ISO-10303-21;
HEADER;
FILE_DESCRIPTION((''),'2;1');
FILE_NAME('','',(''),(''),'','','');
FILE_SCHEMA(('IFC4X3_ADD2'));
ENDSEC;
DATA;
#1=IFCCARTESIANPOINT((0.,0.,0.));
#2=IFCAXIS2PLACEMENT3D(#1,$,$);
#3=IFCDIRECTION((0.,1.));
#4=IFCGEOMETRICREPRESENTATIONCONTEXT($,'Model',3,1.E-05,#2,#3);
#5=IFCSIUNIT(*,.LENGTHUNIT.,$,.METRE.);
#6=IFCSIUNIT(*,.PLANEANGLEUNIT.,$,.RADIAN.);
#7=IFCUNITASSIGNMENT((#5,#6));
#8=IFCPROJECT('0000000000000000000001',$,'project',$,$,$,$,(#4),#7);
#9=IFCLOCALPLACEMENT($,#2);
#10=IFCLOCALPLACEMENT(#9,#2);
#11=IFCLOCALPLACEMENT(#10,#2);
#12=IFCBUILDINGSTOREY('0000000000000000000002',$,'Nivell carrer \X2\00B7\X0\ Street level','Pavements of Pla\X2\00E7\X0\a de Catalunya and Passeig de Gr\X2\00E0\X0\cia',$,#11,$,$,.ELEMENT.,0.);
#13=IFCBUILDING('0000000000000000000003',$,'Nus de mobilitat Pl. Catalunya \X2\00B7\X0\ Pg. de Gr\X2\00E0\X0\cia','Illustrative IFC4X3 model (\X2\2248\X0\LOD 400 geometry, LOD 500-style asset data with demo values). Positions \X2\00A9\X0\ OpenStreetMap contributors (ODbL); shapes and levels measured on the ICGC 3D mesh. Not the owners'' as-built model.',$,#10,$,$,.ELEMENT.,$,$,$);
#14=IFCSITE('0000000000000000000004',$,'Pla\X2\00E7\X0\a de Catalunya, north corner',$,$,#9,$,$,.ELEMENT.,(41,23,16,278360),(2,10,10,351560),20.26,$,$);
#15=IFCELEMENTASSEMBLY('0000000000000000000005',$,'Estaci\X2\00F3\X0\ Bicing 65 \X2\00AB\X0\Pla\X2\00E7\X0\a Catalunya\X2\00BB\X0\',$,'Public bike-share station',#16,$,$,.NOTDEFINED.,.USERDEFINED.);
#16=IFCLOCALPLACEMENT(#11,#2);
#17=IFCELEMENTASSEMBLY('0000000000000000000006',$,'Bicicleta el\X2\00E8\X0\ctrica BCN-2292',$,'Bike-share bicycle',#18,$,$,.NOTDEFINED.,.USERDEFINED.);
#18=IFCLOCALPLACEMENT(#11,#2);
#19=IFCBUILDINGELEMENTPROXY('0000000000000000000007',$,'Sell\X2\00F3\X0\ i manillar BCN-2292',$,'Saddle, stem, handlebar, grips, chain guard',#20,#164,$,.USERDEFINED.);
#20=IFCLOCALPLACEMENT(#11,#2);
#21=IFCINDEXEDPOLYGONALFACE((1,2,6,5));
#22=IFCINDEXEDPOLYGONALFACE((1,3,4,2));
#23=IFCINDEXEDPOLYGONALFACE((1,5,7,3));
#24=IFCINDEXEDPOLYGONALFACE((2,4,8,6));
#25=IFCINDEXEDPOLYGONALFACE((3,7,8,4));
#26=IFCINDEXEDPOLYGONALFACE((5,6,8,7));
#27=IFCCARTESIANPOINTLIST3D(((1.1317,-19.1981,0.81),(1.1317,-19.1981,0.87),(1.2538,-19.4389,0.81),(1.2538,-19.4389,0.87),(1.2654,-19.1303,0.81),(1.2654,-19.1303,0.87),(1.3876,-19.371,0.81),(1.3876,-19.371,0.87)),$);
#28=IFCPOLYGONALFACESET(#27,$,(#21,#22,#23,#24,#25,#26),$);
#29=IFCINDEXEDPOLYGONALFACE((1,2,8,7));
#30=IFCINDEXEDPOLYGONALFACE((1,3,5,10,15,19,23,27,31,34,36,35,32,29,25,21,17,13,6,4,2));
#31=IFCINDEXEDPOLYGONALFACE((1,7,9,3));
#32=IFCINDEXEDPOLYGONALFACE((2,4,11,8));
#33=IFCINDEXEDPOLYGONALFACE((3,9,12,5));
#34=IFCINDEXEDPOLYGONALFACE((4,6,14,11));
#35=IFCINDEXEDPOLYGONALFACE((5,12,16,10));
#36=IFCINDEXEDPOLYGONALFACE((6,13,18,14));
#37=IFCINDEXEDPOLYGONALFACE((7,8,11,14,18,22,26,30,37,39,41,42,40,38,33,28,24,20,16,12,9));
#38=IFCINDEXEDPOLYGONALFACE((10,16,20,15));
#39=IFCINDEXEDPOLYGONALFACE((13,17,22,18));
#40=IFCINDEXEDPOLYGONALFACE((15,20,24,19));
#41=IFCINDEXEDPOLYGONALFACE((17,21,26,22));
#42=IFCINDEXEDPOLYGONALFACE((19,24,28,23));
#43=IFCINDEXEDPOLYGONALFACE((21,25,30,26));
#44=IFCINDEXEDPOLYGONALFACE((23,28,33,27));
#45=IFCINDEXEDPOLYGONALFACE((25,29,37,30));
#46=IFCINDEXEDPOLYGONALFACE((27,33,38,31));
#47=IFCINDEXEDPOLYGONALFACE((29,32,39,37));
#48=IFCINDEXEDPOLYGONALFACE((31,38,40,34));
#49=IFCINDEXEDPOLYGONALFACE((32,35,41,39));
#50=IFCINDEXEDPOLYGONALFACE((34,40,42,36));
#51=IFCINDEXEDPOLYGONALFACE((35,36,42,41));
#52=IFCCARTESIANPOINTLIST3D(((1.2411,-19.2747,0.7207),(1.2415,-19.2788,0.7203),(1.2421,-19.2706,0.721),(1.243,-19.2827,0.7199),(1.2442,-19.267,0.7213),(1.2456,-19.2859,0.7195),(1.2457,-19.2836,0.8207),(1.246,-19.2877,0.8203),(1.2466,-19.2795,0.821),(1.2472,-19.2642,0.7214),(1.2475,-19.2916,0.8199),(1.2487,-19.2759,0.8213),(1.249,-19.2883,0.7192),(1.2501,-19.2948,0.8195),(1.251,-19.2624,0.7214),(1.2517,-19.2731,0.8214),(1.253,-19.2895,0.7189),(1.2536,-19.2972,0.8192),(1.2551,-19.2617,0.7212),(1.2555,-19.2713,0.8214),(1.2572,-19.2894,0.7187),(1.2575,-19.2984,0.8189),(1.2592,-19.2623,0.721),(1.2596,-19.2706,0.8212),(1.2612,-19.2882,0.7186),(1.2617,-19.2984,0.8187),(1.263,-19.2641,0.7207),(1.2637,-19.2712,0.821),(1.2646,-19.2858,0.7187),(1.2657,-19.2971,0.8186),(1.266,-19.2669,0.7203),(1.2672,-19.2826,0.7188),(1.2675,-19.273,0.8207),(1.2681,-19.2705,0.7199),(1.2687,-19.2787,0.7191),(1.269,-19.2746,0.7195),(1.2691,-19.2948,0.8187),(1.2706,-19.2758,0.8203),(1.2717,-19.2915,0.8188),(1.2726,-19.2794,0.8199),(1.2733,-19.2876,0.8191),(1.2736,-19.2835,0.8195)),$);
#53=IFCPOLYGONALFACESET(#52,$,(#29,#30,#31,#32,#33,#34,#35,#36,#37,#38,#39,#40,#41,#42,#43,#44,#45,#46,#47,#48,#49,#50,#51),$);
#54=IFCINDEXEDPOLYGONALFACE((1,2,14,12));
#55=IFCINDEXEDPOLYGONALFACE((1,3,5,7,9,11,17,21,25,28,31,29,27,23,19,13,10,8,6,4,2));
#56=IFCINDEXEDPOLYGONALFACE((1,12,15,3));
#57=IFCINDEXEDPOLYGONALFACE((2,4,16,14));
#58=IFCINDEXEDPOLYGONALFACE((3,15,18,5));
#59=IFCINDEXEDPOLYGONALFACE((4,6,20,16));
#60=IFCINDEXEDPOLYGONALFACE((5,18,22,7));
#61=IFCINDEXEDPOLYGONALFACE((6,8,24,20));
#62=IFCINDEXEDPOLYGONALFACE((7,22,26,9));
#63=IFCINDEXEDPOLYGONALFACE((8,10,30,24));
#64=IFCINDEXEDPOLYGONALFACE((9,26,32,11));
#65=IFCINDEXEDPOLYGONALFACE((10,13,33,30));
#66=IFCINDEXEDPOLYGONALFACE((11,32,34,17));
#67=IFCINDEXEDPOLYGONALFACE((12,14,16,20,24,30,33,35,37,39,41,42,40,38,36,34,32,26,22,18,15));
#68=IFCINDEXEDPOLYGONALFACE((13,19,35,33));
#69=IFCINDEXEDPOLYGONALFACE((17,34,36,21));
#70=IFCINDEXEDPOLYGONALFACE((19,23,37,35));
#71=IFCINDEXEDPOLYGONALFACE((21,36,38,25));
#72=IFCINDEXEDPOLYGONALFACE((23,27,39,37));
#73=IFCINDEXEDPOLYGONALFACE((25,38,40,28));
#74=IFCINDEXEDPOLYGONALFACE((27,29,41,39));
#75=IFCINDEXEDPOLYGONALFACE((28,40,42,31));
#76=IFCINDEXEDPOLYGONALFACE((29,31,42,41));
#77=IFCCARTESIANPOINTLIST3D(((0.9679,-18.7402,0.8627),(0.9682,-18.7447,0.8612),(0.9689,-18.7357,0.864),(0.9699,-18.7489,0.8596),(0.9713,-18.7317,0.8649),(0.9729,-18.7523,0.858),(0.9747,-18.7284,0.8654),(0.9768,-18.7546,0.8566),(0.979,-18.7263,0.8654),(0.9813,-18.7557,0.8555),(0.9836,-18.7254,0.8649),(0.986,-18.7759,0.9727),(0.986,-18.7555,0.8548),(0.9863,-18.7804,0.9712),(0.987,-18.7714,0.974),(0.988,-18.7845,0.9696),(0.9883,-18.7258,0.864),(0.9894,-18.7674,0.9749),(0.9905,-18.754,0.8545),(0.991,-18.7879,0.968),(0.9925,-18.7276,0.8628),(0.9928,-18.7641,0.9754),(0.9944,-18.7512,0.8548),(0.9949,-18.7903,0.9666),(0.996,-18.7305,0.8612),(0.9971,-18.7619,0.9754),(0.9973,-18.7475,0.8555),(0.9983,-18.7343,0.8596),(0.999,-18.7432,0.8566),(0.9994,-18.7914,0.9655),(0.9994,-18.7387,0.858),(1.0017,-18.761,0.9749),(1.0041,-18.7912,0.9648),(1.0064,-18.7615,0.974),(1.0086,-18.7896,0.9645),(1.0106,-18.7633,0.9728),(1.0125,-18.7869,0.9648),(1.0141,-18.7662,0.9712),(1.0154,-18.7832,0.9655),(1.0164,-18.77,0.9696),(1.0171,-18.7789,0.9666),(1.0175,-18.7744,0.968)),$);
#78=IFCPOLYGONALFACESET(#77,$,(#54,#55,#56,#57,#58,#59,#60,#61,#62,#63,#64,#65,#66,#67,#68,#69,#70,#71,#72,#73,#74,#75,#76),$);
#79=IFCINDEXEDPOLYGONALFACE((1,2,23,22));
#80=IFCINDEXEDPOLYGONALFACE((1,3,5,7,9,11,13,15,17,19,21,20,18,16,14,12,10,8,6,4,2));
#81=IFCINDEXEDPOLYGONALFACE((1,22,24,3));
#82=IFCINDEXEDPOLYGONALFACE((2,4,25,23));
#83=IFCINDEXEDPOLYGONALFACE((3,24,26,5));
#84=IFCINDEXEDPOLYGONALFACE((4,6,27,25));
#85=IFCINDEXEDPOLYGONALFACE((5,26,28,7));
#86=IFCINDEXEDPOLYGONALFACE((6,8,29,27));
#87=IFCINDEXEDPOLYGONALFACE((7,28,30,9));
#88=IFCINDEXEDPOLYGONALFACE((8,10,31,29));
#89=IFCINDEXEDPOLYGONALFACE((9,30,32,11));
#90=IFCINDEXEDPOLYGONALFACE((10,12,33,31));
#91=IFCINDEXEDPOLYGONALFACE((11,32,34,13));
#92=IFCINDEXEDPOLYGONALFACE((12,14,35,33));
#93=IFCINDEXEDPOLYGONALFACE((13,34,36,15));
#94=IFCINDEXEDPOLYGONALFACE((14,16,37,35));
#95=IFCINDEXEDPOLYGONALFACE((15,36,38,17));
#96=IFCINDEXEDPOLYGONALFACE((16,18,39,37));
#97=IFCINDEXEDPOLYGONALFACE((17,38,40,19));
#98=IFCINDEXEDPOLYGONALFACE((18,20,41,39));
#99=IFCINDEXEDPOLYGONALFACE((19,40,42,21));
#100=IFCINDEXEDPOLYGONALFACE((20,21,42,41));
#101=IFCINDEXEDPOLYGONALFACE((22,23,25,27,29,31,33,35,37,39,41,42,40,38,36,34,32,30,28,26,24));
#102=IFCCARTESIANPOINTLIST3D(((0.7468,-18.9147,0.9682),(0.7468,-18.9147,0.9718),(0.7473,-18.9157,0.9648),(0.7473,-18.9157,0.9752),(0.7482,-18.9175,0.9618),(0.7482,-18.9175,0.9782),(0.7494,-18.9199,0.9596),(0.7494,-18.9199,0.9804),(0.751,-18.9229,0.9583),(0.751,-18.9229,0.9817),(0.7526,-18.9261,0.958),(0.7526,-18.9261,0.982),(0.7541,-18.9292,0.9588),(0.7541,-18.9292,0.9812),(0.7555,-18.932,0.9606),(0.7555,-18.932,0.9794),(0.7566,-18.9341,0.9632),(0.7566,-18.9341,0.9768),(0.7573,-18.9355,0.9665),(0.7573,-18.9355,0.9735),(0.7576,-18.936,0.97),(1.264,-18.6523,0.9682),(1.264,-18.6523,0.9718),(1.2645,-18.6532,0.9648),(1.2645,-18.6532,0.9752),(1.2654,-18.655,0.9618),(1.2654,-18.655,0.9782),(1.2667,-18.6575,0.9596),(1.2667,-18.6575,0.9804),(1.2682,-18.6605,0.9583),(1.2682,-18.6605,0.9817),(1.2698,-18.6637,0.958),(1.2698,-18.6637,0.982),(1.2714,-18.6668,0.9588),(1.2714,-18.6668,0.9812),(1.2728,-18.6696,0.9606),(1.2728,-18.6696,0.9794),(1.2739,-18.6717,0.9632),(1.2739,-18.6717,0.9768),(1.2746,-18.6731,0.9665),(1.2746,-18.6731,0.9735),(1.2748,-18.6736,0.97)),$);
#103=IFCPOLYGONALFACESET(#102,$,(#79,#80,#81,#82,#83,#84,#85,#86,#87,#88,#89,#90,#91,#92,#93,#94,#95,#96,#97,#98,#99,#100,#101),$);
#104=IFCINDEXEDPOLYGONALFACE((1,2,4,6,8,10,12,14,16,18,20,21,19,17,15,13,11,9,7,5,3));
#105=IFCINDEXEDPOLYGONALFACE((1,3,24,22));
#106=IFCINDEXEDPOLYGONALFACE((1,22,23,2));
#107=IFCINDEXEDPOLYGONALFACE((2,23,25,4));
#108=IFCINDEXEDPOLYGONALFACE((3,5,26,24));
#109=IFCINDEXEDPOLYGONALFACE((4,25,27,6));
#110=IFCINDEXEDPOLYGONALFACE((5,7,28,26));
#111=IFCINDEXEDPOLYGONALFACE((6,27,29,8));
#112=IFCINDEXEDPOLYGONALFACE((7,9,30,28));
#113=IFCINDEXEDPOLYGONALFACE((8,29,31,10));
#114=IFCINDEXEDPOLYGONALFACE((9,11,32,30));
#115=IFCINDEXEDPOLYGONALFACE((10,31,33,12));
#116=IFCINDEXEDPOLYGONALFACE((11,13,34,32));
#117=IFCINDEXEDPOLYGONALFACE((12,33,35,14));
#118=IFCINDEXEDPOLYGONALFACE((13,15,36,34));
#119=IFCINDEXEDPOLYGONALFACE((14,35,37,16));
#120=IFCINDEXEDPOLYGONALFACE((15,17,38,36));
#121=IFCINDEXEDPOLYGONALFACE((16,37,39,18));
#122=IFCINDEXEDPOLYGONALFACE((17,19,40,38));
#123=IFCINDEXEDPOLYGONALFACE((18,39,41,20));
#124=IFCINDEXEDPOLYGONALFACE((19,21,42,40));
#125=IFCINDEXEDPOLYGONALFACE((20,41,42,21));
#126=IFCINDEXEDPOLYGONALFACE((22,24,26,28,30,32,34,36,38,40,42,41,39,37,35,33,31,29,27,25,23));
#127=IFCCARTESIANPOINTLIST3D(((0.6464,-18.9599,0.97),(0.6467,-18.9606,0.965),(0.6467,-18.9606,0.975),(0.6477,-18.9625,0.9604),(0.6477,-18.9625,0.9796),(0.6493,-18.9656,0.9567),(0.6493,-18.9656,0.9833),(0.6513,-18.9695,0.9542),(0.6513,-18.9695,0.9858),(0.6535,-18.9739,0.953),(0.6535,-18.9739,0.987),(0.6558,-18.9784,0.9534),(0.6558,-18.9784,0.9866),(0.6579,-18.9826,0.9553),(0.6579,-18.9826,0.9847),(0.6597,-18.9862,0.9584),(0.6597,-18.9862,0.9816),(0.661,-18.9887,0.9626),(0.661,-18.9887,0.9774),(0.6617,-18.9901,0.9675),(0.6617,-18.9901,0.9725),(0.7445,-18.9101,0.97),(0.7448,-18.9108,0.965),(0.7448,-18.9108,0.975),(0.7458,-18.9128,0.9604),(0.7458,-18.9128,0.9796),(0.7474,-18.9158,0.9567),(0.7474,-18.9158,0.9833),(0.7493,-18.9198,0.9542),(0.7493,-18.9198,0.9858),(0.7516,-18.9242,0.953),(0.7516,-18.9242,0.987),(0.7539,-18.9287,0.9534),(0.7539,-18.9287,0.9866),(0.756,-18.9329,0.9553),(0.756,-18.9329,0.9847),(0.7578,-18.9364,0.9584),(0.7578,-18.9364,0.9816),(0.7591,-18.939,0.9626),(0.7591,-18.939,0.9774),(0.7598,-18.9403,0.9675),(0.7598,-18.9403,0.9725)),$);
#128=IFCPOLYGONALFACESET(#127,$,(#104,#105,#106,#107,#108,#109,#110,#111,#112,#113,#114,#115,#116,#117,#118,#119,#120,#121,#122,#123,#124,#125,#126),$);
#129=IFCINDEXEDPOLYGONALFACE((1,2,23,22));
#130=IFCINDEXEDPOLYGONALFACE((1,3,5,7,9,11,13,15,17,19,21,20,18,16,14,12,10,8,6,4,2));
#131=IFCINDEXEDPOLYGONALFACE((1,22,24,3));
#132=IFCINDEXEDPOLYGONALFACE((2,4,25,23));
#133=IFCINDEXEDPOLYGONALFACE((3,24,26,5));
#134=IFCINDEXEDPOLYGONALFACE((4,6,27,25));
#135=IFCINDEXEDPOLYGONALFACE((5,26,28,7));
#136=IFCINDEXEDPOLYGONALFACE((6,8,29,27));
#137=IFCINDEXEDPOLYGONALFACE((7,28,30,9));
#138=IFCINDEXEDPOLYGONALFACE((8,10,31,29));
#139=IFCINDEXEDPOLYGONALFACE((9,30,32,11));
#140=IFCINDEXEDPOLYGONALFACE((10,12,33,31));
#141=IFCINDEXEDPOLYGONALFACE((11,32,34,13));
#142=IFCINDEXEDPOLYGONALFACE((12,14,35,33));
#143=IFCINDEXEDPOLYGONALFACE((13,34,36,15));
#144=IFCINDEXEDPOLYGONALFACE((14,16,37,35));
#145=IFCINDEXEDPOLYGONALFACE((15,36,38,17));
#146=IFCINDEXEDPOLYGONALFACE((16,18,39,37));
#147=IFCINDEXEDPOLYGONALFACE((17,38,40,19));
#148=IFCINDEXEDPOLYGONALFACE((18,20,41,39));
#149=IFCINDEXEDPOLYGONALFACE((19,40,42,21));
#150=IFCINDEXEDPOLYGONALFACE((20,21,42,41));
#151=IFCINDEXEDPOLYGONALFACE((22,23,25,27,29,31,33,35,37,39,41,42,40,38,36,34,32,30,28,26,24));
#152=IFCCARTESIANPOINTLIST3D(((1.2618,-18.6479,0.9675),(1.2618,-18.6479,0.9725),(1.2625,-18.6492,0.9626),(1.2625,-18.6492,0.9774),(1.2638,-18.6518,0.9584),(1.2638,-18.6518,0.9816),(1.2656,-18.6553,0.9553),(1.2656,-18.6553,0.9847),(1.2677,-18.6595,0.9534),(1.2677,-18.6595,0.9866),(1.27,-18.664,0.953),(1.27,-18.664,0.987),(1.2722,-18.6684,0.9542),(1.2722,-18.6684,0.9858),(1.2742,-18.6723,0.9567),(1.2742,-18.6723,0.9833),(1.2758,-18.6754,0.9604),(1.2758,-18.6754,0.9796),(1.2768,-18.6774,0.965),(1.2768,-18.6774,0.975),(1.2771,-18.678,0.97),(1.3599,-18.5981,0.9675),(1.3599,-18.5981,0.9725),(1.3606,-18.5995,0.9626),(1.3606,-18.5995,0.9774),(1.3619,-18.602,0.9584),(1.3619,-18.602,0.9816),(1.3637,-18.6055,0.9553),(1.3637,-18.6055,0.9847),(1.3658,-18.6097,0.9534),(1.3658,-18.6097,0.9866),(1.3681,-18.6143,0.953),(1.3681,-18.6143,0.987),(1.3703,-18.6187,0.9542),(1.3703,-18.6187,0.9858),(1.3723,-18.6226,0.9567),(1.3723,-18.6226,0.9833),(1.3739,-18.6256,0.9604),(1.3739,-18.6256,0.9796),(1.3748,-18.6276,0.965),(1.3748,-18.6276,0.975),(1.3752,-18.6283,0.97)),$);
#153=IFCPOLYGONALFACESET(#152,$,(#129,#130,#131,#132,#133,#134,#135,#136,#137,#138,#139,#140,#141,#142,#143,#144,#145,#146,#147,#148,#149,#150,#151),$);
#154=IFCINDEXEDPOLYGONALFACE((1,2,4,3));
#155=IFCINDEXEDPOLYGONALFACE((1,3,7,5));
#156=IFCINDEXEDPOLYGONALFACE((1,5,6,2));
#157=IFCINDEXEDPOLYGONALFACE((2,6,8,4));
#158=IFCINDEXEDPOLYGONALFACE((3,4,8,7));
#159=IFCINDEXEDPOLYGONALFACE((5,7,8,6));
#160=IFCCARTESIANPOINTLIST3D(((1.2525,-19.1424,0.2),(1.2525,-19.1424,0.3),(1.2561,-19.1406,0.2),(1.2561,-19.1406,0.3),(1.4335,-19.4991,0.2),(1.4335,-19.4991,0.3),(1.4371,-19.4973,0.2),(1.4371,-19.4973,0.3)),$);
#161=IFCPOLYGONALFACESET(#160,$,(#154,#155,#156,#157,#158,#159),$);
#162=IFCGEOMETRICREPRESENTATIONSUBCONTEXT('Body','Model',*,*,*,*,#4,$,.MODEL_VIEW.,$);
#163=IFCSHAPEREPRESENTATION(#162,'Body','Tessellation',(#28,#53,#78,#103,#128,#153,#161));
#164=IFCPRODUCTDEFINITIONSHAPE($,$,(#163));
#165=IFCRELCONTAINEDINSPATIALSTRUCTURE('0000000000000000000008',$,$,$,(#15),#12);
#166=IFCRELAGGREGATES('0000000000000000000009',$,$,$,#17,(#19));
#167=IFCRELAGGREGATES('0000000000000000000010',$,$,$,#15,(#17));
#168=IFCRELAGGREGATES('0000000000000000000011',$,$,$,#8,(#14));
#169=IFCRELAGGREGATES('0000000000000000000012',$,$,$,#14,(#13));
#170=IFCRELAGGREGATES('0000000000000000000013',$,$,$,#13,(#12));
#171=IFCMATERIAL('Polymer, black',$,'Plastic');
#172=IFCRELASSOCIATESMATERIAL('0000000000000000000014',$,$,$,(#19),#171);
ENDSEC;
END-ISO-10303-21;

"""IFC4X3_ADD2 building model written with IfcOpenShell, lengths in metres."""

from ifc_helpers import new_model, si_unit, direction, frame, origin, origin_2d_with_axis, place, context, subcontext, project, spatial, rectangle, circle, extrude, material, element, aggregate, save


model = new_model("IFC4X3_ADD2")

# Units and contexts
model_context = context("Model", 3, precision=1e-05, world=origin(), true_north=direction((0.0, 1.0)))
body_context = subcontext(model_context, "Body", "Model", "MODEL_VIEW")
ifc_project = project(units=[si_unit("LENGTHUNIT", "METRE"), si_unit("PLANEANGLEUNIT", "RADIAN")], contexts=[model_context])

# Site, building, storey
site_placement = place(None, origin())
site = spatial("IfcSite", under=ifc_project, at=site_placement, Name="Plaça de Catalunya, north corner", CompositionType="ELEMENT", RefLatitude=(41, 23, 16, 278360), RefLongitude=(2, 10, 10, 351560), RefElevation=20.26)
building_placement = place(site_placement, origin())
building = spatial("IfcBuilding", under=site, at=building_placement, Name="Nus de mobilitat Pl. Catalunya · Pg. de Gràcia", Description="Illustrative IFC4X3 model (≈LOD 400 geometry, LOD 500-style asset data with demo values). Positions © OpenStreetMap contributors (ODbL); shapes and levels measured on the ICGC 3D mesh. Not the owners' as-built model.", CompositionType="ELEMENT")
storey_placement = place(building_placement, origin())
storey = spatial("IfcBuildingStorey", under=building, at=storey_placement, Name="Nivell carrer · Street level", Description="Pavements of Plaça de Catalunya and Passeig de Gràcia", CompositionType="ELEMENT", Elevation=0.0)

# Element assemblies, building element proxy
assembly_1_placement = place(building_placement, origin())
assembly_1 = element("IfcElementAssembly", 1, at=assembly_1_placement, inside=storey, Name="Estació Bicing 65 «Plaça Catalunya»", ObjectType="Public bike-share station", AssemblyPlace="NOTDEFINED", PredefinedType="USERDEFINED")
assembly_2_placement = place(building_placement, origin())
assembly_2 = element("IfcElementAssembly", 2, at=assembly_2_placement, Name="Bicicleta elèctrica BCN-2292", ObjectType="Bike-share bicycle", AssemblyPlace="NOTDEFINED", PredefinedType="USERDEFINED")
ifc_material_1 = material(Name="Polymer, black", Category="Plastic")
proxy_1_placement = place(building_placement, origin())
proxy_1 = element("IfcBuildingElementProxy", 3, at=proxy_1_placement, material=ifc_material_1, Name="Selló i manillar BCN-2292", ObjectType="Saddle, stem, handlebar, grips, chain guard", PredefinedType="USERDEFINED", context=body_context, shape_type="SweptSolid", body=[
    extrude(rectangle(XDim=0.27, YDim=0.15, at=origin_2d_with_axis()), frame((1.2596, -19.2846, 0.87), z_axis=(0.0, 0.0, -1.0), x_axis=(-0.452435, 0.891798, 0.0)), (0.0, 0.0, 1.0), 0.06),
    extrude(circle(Radius=0.014, at=origin_2d_with_axis()), frame((1.2551, -19.2757, 0.72), z_axis=(0.045019, -0.088737, 0.995037), x_axis=(0.0, 0.996047, 0.088827)), (0.0, 0.0, 1.0), 0.1005),
    extrude(circle(Radius=0.016, at=origin_2d_with_axis()), frame((0.9836, -18.7406, 0.86), z_axis=(0.154616, -0.304766, 0.939793), x_axis=(0.0, 0.951232, 0.308475)), (0.0, 0.0, 1.0), 0.117),
    extrude(circle(Radius=0.012, at=origin_2d_with_axis()), frame((0.7522, -18.9253, 0.97), z_axis=(0.891798, 0.452435, 0.0), x_axis=(0.452435, -0.891798, 0.0)), (0.0, 0.0, 1.0), 0.58),
    extrude(circle(Radius=0.017, at=origin_2d_with_axis()), frame((0.7522, -18.9253, 0.97), z_axis=(-0.891798, -0.452435, 0.0), x_axis=(-0.452435, 0.891798, 0.0)), (0.0, 0.0, 1.0), 0.11),
    extrude(circle(Radius=0.017, at=origin_2d_with_axis()), frame((1.2694, -18.6629, 0.97), z_axis=(0.891798, 0.452435, 0.0), x_axis=(0.452435, -0.891798, 0.0)), (0.0, 0.0, 1.0), 0.11),
    extrude(rectangle(XDim=0.4, YDim=0.1, at=origin_2d_with_axis()), frame((1.343, -19.3208, 0.25), z_axis=(0.891798, 0.452435, 0.0), x_axis=(-0.452435, 0.891798, 0.0)), (0.0, 0.0, 1.0), 0.004),
])
aggregate(assembly_2, [proxy_1])
aggregate(assembly_1, [assembly_2])

save(model, "model.ifc")
